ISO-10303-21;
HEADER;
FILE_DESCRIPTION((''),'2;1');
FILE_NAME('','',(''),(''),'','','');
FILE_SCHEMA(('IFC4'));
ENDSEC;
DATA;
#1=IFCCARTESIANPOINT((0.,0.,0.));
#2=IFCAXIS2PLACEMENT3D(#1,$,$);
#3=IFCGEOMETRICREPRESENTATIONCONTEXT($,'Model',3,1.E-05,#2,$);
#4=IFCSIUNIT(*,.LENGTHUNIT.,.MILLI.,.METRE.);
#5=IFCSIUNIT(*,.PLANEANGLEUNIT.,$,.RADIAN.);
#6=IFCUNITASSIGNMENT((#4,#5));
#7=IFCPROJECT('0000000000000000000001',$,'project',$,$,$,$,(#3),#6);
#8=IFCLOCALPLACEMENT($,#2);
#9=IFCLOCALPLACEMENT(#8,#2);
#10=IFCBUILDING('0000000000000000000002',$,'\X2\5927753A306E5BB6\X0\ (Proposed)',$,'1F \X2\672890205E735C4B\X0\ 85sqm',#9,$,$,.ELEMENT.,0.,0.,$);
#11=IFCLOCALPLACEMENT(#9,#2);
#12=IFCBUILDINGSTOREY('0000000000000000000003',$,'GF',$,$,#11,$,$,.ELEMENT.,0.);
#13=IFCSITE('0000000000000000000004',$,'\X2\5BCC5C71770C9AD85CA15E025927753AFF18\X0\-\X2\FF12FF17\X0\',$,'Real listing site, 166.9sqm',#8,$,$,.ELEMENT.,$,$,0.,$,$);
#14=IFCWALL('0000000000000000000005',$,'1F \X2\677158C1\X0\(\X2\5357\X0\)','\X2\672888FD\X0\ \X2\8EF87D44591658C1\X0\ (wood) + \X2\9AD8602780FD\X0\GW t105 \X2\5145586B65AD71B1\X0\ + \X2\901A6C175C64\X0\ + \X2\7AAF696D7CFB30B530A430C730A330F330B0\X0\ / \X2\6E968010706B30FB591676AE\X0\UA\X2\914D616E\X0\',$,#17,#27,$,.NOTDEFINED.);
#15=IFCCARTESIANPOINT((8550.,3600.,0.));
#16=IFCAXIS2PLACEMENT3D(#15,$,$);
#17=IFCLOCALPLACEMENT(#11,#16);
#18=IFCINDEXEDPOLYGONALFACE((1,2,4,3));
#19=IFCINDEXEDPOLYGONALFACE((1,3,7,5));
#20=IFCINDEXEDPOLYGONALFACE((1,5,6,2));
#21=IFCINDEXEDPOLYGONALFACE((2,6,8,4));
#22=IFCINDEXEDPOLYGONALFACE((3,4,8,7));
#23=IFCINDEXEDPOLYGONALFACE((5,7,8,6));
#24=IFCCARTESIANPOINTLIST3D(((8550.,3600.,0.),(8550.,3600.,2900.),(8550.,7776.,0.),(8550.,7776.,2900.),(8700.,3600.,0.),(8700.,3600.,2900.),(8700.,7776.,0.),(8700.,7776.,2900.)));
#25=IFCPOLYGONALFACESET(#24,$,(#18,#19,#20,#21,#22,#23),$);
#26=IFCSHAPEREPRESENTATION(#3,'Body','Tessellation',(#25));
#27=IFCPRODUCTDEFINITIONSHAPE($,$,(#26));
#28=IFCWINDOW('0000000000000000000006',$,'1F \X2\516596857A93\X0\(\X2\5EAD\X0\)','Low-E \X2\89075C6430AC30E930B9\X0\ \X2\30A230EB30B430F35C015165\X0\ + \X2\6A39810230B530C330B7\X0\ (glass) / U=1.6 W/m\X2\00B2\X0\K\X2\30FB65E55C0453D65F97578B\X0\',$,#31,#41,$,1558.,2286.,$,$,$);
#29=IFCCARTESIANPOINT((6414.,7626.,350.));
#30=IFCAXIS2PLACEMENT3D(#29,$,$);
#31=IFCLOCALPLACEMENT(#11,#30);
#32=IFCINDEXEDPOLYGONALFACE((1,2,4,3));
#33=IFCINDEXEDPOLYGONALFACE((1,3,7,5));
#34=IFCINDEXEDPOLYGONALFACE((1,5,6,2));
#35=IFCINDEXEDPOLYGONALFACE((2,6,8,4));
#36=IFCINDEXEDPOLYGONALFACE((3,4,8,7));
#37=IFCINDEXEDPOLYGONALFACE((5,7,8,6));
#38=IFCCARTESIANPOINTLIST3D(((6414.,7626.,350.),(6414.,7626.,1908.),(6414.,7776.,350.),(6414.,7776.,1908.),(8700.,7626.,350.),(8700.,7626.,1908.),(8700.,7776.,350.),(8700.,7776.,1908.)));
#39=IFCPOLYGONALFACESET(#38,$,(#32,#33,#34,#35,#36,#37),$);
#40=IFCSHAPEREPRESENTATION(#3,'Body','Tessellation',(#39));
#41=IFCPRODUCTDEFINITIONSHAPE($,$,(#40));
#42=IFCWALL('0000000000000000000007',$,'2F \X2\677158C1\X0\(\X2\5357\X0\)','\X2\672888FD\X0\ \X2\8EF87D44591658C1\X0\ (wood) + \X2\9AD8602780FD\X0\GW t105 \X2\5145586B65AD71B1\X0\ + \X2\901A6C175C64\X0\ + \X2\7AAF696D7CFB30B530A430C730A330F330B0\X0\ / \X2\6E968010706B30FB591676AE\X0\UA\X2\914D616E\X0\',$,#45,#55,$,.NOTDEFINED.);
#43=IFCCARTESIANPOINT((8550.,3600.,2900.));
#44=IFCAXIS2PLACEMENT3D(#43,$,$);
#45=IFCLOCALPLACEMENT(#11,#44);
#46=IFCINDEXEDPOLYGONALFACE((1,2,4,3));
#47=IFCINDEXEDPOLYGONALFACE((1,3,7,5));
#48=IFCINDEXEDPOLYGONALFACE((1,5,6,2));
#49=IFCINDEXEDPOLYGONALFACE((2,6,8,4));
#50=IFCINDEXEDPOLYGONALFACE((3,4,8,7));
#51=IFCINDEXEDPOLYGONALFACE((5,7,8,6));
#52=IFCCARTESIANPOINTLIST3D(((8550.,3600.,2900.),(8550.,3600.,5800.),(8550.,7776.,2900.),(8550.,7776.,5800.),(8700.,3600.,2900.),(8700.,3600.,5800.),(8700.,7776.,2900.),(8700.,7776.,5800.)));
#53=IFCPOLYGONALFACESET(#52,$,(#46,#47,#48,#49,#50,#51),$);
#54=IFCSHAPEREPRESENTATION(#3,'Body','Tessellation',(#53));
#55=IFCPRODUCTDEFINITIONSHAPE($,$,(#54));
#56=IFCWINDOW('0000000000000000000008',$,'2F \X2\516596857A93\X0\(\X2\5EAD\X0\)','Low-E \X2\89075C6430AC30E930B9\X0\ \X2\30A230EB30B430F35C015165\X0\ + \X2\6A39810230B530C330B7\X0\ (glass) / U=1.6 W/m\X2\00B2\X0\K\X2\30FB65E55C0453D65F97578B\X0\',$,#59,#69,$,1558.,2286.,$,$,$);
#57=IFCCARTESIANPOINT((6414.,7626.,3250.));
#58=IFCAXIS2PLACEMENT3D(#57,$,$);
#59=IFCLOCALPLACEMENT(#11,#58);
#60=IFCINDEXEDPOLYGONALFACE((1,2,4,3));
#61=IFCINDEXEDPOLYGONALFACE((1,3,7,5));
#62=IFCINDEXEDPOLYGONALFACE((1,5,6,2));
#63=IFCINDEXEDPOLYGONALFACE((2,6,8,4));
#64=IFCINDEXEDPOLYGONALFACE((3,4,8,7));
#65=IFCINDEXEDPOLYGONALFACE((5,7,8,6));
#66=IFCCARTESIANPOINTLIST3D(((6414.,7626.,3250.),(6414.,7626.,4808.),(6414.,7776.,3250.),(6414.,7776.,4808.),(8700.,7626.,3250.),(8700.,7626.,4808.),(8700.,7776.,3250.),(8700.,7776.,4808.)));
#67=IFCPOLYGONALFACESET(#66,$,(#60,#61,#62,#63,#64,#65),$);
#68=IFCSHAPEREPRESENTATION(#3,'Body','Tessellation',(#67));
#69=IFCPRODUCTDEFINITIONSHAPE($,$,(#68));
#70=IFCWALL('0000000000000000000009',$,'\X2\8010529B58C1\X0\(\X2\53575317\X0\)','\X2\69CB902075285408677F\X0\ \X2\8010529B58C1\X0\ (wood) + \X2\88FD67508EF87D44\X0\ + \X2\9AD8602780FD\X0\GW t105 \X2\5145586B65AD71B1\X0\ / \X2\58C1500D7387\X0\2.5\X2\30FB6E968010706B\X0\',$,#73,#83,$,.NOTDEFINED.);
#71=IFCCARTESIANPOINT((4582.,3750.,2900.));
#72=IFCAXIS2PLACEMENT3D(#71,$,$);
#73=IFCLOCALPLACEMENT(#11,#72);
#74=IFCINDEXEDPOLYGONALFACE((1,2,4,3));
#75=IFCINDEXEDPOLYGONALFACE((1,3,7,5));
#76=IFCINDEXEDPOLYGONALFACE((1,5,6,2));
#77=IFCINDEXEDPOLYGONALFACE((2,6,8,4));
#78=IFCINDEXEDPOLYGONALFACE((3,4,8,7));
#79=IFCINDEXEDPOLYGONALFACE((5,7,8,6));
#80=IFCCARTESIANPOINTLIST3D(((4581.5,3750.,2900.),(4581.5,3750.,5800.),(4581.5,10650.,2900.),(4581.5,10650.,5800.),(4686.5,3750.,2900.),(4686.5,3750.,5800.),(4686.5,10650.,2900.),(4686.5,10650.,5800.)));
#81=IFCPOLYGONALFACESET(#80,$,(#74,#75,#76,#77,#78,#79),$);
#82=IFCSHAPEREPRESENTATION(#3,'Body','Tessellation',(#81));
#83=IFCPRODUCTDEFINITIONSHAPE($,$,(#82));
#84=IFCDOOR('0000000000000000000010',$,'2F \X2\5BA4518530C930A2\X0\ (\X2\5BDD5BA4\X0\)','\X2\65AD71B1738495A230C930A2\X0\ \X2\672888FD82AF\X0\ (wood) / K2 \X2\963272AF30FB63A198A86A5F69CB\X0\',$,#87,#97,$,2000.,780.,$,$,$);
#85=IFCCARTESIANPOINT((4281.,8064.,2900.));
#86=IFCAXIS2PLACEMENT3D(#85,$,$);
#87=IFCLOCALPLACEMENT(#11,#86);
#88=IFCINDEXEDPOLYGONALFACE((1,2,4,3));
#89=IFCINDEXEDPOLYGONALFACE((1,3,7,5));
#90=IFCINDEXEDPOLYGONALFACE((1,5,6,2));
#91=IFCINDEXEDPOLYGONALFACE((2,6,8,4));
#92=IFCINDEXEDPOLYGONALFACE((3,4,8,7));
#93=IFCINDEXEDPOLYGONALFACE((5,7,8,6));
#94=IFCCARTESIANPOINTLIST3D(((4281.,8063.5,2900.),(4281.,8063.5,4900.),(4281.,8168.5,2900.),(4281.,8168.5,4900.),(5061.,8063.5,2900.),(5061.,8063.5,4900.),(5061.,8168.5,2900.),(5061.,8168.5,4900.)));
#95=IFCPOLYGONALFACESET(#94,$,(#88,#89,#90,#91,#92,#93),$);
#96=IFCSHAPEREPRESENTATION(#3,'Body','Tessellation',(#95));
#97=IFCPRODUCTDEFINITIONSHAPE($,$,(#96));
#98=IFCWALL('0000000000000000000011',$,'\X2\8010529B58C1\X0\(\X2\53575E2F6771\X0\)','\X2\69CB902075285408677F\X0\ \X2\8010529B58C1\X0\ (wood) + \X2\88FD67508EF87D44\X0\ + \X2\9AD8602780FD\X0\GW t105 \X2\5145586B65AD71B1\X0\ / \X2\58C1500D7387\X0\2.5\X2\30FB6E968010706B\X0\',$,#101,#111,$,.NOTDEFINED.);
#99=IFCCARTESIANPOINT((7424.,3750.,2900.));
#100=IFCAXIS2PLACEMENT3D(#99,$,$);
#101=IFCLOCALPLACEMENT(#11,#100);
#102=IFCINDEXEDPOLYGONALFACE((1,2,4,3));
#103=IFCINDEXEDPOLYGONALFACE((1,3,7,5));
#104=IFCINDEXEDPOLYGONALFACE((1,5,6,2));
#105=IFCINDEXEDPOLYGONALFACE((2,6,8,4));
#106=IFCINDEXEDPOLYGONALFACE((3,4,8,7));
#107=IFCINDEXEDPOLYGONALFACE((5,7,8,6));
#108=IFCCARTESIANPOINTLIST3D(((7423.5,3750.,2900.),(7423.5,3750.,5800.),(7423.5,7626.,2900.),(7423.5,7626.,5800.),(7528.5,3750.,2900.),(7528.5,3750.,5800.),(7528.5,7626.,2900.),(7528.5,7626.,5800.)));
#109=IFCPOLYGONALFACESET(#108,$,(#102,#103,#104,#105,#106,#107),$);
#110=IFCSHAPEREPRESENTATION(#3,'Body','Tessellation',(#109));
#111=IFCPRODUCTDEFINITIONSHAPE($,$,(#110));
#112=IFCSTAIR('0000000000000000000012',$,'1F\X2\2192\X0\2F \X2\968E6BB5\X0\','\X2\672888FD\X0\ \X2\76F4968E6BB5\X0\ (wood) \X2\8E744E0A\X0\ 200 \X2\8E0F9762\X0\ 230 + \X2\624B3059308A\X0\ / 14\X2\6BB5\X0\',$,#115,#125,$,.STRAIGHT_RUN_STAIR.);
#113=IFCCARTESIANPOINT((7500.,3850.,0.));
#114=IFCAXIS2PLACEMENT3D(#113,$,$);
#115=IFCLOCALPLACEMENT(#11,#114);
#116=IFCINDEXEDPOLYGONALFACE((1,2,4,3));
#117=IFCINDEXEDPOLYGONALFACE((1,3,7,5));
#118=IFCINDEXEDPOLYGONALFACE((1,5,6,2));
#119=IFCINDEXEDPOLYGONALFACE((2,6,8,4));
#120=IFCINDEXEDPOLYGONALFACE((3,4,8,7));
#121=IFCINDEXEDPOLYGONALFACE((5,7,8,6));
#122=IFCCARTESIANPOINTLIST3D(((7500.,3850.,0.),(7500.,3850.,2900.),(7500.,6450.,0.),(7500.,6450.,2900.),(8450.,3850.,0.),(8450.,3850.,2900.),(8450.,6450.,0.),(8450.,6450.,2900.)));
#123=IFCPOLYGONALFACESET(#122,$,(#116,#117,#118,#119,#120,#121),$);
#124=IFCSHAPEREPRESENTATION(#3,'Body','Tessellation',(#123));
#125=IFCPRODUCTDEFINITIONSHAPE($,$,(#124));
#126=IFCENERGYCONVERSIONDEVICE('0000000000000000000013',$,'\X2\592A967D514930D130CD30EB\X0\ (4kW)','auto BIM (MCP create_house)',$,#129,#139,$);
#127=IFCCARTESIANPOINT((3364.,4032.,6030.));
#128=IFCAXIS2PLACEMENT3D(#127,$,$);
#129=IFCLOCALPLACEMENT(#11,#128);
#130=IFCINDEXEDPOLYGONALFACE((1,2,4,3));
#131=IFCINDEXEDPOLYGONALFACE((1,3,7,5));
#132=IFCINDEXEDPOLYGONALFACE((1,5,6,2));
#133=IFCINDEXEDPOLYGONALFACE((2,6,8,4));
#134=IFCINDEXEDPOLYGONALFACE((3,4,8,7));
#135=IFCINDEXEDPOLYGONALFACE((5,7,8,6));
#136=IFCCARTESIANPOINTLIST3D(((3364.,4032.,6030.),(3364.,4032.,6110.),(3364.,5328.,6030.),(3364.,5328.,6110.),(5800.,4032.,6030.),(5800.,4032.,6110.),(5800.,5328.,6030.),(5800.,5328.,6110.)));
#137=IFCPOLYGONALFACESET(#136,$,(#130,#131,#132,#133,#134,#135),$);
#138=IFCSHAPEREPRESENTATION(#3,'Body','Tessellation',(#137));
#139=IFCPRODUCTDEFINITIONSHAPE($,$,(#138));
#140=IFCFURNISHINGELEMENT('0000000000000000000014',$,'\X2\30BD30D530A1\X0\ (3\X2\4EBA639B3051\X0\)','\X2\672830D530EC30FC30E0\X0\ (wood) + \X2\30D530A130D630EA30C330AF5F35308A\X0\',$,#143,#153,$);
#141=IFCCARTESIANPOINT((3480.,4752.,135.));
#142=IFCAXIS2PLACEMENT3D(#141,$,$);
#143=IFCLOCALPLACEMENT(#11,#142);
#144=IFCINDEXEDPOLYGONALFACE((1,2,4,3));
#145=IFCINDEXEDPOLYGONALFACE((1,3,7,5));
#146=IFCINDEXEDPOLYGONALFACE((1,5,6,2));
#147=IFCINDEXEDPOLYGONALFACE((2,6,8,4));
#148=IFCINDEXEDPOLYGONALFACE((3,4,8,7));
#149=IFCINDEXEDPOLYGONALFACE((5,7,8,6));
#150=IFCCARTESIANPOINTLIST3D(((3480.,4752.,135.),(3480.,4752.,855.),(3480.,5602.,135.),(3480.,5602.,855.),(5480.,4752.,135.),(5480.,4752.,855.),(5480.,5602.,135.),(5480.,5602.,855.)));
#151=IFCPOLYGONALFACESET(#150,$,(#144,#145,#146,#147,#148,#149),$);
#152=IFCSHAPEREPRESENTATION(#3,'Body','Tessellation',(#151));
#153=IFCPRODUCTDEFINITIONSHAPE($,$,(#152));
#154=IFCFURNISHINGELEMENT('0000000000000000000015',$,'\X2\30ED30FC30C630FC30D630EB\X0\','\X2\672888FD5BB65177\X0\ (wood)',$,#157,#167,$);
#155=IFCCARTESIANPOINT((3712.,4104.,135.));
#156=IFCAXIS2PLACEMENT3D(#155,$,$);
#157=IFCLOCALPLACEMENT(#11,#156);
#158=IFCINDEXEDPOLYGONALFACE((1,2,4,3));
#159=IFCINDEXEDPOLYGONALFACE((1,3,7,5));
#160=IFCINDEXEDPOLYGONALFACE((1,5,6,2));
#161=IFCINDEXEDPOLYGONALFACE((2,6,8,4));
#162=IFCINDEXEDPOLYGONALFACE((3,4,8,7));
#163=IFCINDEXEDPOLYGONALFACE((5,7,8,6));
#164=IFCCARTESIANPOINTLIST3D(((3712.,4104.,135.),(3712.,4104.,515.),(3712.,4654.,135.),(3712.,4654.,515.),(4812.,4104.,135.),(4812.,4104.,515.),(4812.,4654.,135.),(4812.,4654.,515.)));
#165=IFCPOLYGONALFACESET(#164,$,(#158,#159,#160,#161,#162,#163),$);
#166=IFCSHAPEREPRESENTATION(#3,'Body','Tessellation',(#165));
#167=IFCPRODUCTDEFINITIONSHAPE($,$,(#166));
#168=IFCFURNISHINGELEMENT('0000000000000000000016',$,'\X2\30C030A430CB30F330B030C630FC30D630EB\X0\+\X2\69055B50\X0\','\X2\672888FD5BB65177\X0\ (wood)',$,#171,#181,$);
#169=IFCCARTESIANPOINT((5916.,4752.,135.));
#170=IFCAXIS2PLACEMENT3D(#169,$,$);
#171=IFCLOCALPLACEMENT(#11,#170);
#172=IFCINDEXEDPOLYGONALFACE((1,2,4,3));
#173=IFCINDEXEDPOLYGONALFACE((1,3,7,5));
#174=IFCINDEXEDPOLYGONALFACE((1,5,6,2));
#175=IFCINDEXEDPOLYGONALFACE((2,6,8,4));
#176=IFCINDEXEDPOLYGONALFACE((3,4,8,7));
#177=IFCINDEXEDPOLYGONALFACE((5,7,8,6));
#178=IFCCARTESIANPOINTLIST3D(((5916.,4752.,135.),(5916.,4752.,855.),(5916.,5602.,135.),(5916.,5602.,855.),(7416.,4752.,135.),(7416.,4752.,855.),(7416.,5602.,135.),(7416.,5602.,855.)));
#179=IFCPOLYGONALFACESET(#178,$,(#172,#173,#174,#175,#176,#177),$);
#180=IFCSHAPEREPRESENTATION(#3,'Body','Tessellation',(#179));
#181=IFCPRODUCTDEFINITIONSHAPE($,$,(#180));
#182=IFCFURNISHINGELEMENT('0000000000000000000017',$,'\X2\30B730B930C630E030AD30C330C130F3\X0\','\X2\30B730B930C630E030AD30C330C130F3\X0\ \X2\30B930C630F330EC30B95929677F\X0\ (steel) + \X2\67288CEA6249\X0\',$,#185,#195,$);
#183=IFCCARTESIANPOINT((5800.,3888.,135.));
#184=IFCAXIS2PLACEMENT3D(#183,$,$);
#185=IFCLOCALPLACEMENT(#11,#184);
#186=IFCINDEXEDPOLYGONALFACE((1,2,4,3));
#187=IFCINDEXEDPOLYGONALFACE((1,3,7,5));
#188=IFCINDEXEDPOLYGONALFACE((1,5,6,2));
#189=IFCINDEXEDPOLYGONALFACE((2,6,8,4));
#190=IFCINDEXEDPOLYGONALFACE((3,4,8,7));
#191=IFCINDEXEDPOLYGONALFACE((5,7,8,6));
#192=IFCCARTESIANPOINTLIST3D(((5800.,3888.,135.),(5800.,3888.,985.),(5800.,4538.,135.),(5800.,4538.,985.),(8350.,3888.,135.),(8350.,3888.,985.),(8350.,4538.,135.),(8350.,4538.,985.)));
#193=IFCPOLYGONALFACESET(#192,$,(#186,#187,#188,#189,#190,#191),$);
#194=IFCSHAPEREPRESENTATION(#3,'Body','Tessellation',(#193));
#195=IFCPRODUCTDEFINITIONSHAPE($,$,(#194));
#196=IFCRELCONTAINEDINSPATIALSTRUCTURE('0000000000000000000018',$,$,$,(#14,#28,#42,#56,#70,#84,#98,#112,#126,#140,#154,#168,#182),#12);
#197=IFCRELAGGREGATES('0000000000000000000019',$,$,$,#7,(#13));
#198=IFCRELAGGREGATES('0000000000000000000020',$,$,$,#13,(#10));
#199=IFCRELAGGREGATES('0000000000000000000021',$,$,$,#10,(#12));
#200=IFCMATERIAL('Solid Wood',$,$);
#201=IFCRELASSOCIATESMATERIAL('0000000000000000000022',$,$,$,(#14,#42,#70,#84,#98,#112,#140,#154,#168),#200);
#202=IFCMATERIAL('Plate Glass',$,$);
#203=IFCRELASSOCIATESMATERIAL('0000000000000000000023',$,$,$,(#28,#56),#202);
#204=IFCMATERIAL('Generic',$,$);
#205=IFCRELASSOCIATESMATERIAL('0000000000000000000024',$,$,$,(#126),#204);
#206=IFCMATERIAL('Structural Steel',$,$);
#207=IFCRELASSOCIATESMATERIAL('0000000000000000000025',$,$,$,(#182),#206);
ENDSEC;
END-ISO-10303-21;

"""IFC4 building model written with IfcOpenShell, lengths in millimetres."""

from ifc_helpers import new_model, si_unit, frame, frame_2d, origin, place, context, project, spatial, rectangle, extrude, material, element, fill, save


model = new_model("IFC4")

# Units and contexts
model_context = context("Model", 3, precision=1e-05, world=origin())
ifc_project = project(units=[si_unit("LENGTHUNIT", "METRE", prefix="MILLI"), si_unit("PLANEANGLEUNIT", "RADIAN")], contexts=[model_context])

# Site, building, storey
site_placement = place(None, origin())
site = spatial("IfcSite", under=ifc_project, at=site_placement, Name="富山県高岡市大町８-２７", ObjectType="Real listing site, 166.9sqm", CompositionType="ELEMENT", RefElevation=0.0)
building_placement = place(site_placement, origin())
building = spatial("IfcBuilding", under=site, at=building_placement, Name="大町の家 (Proposed)", ObjectType="1F 木造平屋 85sqm", CompositionType="ELEMENT", ElevationOfRefHeight=0.0, ElevationOfTerrain=0.0)
storey_placement = place(building_placement, origin())
storey = spatial("IfcBuildingStorey", under=building, at=storey_placement, Name="GF", CompositionType="ELEMENT", Elevation=0.0)

# Wall, opening, window
ifc_material_1 = material(Name="Solid Wood")
wall_1_placement = place(storey_placement, frame((8550.0, 3600.0, 0.0)))
wall_1 = element("IfcWall", 1, at=wall_1_placement, inside=storey, material=ifc_material_1, Name="1F 東壁(南)", Description="木製 軸組外壁 (wood) + 高性能GW t105 充填断熱 + 通気層 + 窯業系サイディング / 準耐火・外皮UA配慮", PredefinedType="NOTDEFINED", context=model_context, shape_type="SweptSolid", body=[
    extrude(rectangle(XDim=150.0, YDim=4176.0, at=frame_2d((75.0, 2088.0))), frame((8550.0, 3600.0, 0.0)), (0.0, 0.0, 1.0), 2900.0),
])
opening_1_placement = place(storey_placement, frame((6414.0, 7626.0, 350.0)))
opening_1 = element("IfcOpeningElement", 2, at=opening_1_placement, cuts=wall_1, PredefinedType="NOTDEFINED", context=model_context, shape_type="SweptSolid", body=[
    extrude(rectangle(XDim=2286.0, YDim=150.0, at=frame_2d((1143.0, 75.0))), frame((6414.0, 7626.0, 350.0)), (0.0, 0.0, 1.0), 1558.0),
])
ifc_material_2 = material(Name="Plate Glass")
window_1_placement = place(storey_placement, frame((6414.0, 7626.0, 350.0)))
window_1 = element("IfcWindow", 3, at=window_1_placement, inside=storey, material=ifc_material_2, Name="1F 入隅窓(庭)", Description="Low-E 複層ガラス アルゴン封入 + 樹脂サッシ (glass) / U=1.6 W/m²K・日射取得型", OverallHeight=1558.0, OverallWidth=2286.0, context=model_context, shape_type="SweptSolid", body=[
    extrude(rectangle(XDim=2286.0, YDim=150.0, at=frame_2d((1143.0, 75.0))), frame((6414.0, 7626.0, 350.0)), (0.0, 0.0, 1.0), 1558.0),
])
fill(opening_1, window_1)

# Wall, opening, window
wall_2_placement = place(storey_placement, frame((8550.0, 3600.0, 2900.0)))
wall_2 = element("IfcWall", 4, at=wall_2_placement, inside=storey, material=ifc_material_1, Name="2F 東壁(南)", Description="木製 軸組外壁 (wood) + 高性能GW t105 充填断熱 + 通気層 + 窯業系サイディング / 準耐火・外皮UA配慮", PredefinedType="NOTDEFINED", context=model_context, shape_type="SweptSolid", body=[
    extrude(rectangle(XDim=150.0, YDim=4176.0, at=frame_2d((75.0, 2088.0))), frame((8550.0, 3600.0, 2900.0)), (0.0, 0.0, 1.0), 2900.0),
])
opening_2_placement = place(storey_placement, frame((6414.0, 7626.0, 3250.0)))
opening_2 = element("IfcOpeningElement", 5, at=opening_2_placement, cuts=wall_2, PredefinedType="NOTDEFINED", context=model_context, shape_type="SweptSolid", body=[
    extrude(rectangle(XDim=2286.0, YDim=150.0, at=frame_2d((1143.0, 75.0))), frame((6414.0, 7626.0, 3250.0)), (0.0, 0.0, 1.0), 1558.0),
])
window_2_placement = place(storey_placement, frame((6414.0, 7626.0, 3250.0)))
window_2 = element("IfcWindow", 6, at=window_2_placement, inside=storey, material=ifc_material_2, Name="2F 入隅窓(庭)", Description="Low-E 複層ガラス アルゴン封入 + 樹脂サッシ (glass) / U=1.6 W/m²K・日射取得型", OverallHeight=1558.0, OverallWidth=2286.0, context=model_context, shape_type="SweptSolid", body=[
    extrude(rectangle(XDim=2286.0, YDim=150.0, at=frame_2d((1143.0, 75.0))), frame((6414.0, 7626.0, 3250.0)), (0.0, 0.0, 1.0), 1558.0),
])
fill(opening_2, window_2)

# Wall, opening, door
wall_3_placement = place(storey_placement, frame((4582.0, 3750.0, 2900.0)))
wall_3 = element("IfcWall", 7, at=wall_3_placement, inside=storey, material=ifc_material_1, Name="耐力壁(南北)", Description="構造用合板 耐力壁 (wood) + 製材軸組 + 高性能GW t105 充填断熱 / 壁倍率2.5・準耐火", PredefinedType="NOTDEFINED", context=model_context, shape_type="SweptSolid", body=[
    extrude(rectangle(XDim=105.0, YDim=6900.0, at=frame_2d((52.0, 3450.0))), frame((4582.0, 3750.0, 2900.0)), (0.0, 0.0, 1.0), 2900.0),
])
opening_3_placement = place(storey_placement, frame((4281.0, 8064.0, 2900.0)))
opening_3 = element("IfcOpeningElement", 8, at=opening_3_placement, cuts=wall_3, PredefinedType="NOTDEFINED", context=model_context, shape_type="SweptSolid", body=[
    extrude(rectangle(XDim=780.0, YDim=105.0, at=frame_2d((390.0, 52.0))), frame((4281.0, 8064.0, 2900.0)), (0.0, 0.0, 1.0), 2000.0),
])
door_1_placement = place(storey_placement, frame((4281.0, 8064.0, 2900.0)))
door_1 = element("IfcDoor", 9, at=door_1_placement, inside=storey, material=ifc_material_1, Name="2F 室内ドア (寝室)", Description="断熱玄関ドア 木製芯 (wood) / K2 防犯・採風機構", OverallHeight=2000.0, OverallWidth=780.0, context=model_context, shape_type="SweptSolid", body=[
    extrude(rectangle(XDim=780.0, YDim=105.0, at=frame_2d((390.0, 52.0))), frame((4281.0, 8064.0, 2900.0)), (0.0, 0.0, 1.0), 2000.0),
])
fill(opening_3, door_1)

# Wall
wall_4_placement = place(storey_placement, frame((7424.0, 3750.0, 2900.0)))
element("IfcWall", 10, at=wall_4_placement, inside=storey, material=ifc_material_1, Name="耐力壁(南帯東)", Description="構造用合板 耐力壁 (wood) + 製材軸組 + 高性能GW t105 充填断熱 / 壁倍率2.5・準耐火", PredefinedType="NOTDEFINED", context=model_context, shape_type="SweptSolid", body=[
    extrude(rectangle(XDim=105.0, YDim=3876.0, at=frame_2d((52.0, 1938.0))), frame((7424.0, 3750.0, 2900.0)), (0.0, 0.0, 1.0), 2900.0),
])

# Stair
stair_placement = place(storey_placement, frame((7500.0, 3850.0, 0.0)))
element("IfcStair", 11, at=stair_placement, inside=storey, material=ifc_material_1, Name="1F→2F 階段", Description="木製 直階段 (wood) 蹴上 200 踏面 230 + 手すり / 14段", PredefinedType="STRAIGHT_RUN_STAIR", context=model_context, shape_type="SweptSolid", body=[
    extrude(rectangle(XDim=950.0, YDim=2600.0, at=frame_2d((475.0, 1300.0))), frame((7500.0, 3850.0, 0.0)), (0.0, 0.0, 1.0), 2900.0),
])

# Energy conversion device
ifc_material_3 = material(Name="Generic")
energy_conversion_device_placement = place(storey_placement, frame((3364.0, 4032.0, 6030.0)))
element("IfcEnergyConversionDevice", 12, at=energy_conversion_device_placement, inside=storey, material=ifc_material_3, Name="太陽光パネル (4kW)", Description="auto BIM (MCP create_house)", context=model_context, shape_type="SweptSolid", body=[
    extrude(rectangle(XDim=2436.0, YDim=1296.0, at=frame_2d((1218.0, 648.0))), frame((3364.0, 4032.0, 6030.0)), (0.0, 0.0, 1.0), 80.0),
])

# Furnishing elements
furnishing_1_placement = place(storey_placement, frame((3480.0, 4752.0, 135.0)))
element("IfcFurnishingElement", 13, at=furnishing_1_placement, inside=storey, material=ifc_material_1, Name="ソファ (3人掛け)", Description="木フレーム (wood) + ファブリック張り", context=model_context, shape_type="SweptSolid", body=[
    extrude(rectangle(XDim=2000.0, YDim=850.0, at=frame_2d((1000.0, 425.0))), frame((3480.0, 4752.0, 135.0)), (0.0, 0.0, 1.0), 720.0),
])
furnishing_2_placement = place(storey_placement, frame((3712.0, 4104.0, 135.0)))
element("IfcFurnishingElement", 14, at=furnishing_2_placement, inside=storey, material=ifc_material_1, Name="ローテーブル", Description="木製家具 (wood)", context=model_context, shape_type="SweptSolid", body=[
    extrude(rectangle(XDim=1100.0, YDim=550.0, at=frame_2d((550.0, 275.0))), frame((3712.0, 4104.0, 135.0)), (0.0, 0.0, 1.0), 380.0),
])
furnishing_3_placement = place(storey_placement, frame((5916.0, 4752.0, 135.0)))
element("IfcFurnishingElement", 15, at=furnishing_3_placement, inside=storey, material=ifc_material_1, Name="ダイニングテーブル+椅子", Description="木製家具 (wood)", context=model_context, shape_type="SweptSolid", body=[
    extrude(rectangle(XDim=1500.0, YDim=850.0, at=frame_2d((750.0, 425.0))), frame((5916.0, 4752.0, 135.0)), (0.0, 0.0, 1.0), 720.0),
])
ifc_material_4 = material(Name="Structural Steel")
furnishing_4_placement = place(storey_placement, frame((5800.0, 3888.0, 135.0)))
element("IfcFurnishingElement", 16, at=furnishing_4_placement, inside=storey, material=ifc_material_4, Name="システムキッチン", Description="システムキッチン ステンレス天板 (steel) + 木質扉", context=model_context, shape_type="SweptSolid", body=[
    extrude(rectangle(XDim=2550.0, YDim=650.0, at=frame_2d((1275.0, 325.0))), frame((5800.0, 3888.0, 135.0)), (0.0, 0.0, 1.0), 850.0),
])

save(model, "model.ifc")
